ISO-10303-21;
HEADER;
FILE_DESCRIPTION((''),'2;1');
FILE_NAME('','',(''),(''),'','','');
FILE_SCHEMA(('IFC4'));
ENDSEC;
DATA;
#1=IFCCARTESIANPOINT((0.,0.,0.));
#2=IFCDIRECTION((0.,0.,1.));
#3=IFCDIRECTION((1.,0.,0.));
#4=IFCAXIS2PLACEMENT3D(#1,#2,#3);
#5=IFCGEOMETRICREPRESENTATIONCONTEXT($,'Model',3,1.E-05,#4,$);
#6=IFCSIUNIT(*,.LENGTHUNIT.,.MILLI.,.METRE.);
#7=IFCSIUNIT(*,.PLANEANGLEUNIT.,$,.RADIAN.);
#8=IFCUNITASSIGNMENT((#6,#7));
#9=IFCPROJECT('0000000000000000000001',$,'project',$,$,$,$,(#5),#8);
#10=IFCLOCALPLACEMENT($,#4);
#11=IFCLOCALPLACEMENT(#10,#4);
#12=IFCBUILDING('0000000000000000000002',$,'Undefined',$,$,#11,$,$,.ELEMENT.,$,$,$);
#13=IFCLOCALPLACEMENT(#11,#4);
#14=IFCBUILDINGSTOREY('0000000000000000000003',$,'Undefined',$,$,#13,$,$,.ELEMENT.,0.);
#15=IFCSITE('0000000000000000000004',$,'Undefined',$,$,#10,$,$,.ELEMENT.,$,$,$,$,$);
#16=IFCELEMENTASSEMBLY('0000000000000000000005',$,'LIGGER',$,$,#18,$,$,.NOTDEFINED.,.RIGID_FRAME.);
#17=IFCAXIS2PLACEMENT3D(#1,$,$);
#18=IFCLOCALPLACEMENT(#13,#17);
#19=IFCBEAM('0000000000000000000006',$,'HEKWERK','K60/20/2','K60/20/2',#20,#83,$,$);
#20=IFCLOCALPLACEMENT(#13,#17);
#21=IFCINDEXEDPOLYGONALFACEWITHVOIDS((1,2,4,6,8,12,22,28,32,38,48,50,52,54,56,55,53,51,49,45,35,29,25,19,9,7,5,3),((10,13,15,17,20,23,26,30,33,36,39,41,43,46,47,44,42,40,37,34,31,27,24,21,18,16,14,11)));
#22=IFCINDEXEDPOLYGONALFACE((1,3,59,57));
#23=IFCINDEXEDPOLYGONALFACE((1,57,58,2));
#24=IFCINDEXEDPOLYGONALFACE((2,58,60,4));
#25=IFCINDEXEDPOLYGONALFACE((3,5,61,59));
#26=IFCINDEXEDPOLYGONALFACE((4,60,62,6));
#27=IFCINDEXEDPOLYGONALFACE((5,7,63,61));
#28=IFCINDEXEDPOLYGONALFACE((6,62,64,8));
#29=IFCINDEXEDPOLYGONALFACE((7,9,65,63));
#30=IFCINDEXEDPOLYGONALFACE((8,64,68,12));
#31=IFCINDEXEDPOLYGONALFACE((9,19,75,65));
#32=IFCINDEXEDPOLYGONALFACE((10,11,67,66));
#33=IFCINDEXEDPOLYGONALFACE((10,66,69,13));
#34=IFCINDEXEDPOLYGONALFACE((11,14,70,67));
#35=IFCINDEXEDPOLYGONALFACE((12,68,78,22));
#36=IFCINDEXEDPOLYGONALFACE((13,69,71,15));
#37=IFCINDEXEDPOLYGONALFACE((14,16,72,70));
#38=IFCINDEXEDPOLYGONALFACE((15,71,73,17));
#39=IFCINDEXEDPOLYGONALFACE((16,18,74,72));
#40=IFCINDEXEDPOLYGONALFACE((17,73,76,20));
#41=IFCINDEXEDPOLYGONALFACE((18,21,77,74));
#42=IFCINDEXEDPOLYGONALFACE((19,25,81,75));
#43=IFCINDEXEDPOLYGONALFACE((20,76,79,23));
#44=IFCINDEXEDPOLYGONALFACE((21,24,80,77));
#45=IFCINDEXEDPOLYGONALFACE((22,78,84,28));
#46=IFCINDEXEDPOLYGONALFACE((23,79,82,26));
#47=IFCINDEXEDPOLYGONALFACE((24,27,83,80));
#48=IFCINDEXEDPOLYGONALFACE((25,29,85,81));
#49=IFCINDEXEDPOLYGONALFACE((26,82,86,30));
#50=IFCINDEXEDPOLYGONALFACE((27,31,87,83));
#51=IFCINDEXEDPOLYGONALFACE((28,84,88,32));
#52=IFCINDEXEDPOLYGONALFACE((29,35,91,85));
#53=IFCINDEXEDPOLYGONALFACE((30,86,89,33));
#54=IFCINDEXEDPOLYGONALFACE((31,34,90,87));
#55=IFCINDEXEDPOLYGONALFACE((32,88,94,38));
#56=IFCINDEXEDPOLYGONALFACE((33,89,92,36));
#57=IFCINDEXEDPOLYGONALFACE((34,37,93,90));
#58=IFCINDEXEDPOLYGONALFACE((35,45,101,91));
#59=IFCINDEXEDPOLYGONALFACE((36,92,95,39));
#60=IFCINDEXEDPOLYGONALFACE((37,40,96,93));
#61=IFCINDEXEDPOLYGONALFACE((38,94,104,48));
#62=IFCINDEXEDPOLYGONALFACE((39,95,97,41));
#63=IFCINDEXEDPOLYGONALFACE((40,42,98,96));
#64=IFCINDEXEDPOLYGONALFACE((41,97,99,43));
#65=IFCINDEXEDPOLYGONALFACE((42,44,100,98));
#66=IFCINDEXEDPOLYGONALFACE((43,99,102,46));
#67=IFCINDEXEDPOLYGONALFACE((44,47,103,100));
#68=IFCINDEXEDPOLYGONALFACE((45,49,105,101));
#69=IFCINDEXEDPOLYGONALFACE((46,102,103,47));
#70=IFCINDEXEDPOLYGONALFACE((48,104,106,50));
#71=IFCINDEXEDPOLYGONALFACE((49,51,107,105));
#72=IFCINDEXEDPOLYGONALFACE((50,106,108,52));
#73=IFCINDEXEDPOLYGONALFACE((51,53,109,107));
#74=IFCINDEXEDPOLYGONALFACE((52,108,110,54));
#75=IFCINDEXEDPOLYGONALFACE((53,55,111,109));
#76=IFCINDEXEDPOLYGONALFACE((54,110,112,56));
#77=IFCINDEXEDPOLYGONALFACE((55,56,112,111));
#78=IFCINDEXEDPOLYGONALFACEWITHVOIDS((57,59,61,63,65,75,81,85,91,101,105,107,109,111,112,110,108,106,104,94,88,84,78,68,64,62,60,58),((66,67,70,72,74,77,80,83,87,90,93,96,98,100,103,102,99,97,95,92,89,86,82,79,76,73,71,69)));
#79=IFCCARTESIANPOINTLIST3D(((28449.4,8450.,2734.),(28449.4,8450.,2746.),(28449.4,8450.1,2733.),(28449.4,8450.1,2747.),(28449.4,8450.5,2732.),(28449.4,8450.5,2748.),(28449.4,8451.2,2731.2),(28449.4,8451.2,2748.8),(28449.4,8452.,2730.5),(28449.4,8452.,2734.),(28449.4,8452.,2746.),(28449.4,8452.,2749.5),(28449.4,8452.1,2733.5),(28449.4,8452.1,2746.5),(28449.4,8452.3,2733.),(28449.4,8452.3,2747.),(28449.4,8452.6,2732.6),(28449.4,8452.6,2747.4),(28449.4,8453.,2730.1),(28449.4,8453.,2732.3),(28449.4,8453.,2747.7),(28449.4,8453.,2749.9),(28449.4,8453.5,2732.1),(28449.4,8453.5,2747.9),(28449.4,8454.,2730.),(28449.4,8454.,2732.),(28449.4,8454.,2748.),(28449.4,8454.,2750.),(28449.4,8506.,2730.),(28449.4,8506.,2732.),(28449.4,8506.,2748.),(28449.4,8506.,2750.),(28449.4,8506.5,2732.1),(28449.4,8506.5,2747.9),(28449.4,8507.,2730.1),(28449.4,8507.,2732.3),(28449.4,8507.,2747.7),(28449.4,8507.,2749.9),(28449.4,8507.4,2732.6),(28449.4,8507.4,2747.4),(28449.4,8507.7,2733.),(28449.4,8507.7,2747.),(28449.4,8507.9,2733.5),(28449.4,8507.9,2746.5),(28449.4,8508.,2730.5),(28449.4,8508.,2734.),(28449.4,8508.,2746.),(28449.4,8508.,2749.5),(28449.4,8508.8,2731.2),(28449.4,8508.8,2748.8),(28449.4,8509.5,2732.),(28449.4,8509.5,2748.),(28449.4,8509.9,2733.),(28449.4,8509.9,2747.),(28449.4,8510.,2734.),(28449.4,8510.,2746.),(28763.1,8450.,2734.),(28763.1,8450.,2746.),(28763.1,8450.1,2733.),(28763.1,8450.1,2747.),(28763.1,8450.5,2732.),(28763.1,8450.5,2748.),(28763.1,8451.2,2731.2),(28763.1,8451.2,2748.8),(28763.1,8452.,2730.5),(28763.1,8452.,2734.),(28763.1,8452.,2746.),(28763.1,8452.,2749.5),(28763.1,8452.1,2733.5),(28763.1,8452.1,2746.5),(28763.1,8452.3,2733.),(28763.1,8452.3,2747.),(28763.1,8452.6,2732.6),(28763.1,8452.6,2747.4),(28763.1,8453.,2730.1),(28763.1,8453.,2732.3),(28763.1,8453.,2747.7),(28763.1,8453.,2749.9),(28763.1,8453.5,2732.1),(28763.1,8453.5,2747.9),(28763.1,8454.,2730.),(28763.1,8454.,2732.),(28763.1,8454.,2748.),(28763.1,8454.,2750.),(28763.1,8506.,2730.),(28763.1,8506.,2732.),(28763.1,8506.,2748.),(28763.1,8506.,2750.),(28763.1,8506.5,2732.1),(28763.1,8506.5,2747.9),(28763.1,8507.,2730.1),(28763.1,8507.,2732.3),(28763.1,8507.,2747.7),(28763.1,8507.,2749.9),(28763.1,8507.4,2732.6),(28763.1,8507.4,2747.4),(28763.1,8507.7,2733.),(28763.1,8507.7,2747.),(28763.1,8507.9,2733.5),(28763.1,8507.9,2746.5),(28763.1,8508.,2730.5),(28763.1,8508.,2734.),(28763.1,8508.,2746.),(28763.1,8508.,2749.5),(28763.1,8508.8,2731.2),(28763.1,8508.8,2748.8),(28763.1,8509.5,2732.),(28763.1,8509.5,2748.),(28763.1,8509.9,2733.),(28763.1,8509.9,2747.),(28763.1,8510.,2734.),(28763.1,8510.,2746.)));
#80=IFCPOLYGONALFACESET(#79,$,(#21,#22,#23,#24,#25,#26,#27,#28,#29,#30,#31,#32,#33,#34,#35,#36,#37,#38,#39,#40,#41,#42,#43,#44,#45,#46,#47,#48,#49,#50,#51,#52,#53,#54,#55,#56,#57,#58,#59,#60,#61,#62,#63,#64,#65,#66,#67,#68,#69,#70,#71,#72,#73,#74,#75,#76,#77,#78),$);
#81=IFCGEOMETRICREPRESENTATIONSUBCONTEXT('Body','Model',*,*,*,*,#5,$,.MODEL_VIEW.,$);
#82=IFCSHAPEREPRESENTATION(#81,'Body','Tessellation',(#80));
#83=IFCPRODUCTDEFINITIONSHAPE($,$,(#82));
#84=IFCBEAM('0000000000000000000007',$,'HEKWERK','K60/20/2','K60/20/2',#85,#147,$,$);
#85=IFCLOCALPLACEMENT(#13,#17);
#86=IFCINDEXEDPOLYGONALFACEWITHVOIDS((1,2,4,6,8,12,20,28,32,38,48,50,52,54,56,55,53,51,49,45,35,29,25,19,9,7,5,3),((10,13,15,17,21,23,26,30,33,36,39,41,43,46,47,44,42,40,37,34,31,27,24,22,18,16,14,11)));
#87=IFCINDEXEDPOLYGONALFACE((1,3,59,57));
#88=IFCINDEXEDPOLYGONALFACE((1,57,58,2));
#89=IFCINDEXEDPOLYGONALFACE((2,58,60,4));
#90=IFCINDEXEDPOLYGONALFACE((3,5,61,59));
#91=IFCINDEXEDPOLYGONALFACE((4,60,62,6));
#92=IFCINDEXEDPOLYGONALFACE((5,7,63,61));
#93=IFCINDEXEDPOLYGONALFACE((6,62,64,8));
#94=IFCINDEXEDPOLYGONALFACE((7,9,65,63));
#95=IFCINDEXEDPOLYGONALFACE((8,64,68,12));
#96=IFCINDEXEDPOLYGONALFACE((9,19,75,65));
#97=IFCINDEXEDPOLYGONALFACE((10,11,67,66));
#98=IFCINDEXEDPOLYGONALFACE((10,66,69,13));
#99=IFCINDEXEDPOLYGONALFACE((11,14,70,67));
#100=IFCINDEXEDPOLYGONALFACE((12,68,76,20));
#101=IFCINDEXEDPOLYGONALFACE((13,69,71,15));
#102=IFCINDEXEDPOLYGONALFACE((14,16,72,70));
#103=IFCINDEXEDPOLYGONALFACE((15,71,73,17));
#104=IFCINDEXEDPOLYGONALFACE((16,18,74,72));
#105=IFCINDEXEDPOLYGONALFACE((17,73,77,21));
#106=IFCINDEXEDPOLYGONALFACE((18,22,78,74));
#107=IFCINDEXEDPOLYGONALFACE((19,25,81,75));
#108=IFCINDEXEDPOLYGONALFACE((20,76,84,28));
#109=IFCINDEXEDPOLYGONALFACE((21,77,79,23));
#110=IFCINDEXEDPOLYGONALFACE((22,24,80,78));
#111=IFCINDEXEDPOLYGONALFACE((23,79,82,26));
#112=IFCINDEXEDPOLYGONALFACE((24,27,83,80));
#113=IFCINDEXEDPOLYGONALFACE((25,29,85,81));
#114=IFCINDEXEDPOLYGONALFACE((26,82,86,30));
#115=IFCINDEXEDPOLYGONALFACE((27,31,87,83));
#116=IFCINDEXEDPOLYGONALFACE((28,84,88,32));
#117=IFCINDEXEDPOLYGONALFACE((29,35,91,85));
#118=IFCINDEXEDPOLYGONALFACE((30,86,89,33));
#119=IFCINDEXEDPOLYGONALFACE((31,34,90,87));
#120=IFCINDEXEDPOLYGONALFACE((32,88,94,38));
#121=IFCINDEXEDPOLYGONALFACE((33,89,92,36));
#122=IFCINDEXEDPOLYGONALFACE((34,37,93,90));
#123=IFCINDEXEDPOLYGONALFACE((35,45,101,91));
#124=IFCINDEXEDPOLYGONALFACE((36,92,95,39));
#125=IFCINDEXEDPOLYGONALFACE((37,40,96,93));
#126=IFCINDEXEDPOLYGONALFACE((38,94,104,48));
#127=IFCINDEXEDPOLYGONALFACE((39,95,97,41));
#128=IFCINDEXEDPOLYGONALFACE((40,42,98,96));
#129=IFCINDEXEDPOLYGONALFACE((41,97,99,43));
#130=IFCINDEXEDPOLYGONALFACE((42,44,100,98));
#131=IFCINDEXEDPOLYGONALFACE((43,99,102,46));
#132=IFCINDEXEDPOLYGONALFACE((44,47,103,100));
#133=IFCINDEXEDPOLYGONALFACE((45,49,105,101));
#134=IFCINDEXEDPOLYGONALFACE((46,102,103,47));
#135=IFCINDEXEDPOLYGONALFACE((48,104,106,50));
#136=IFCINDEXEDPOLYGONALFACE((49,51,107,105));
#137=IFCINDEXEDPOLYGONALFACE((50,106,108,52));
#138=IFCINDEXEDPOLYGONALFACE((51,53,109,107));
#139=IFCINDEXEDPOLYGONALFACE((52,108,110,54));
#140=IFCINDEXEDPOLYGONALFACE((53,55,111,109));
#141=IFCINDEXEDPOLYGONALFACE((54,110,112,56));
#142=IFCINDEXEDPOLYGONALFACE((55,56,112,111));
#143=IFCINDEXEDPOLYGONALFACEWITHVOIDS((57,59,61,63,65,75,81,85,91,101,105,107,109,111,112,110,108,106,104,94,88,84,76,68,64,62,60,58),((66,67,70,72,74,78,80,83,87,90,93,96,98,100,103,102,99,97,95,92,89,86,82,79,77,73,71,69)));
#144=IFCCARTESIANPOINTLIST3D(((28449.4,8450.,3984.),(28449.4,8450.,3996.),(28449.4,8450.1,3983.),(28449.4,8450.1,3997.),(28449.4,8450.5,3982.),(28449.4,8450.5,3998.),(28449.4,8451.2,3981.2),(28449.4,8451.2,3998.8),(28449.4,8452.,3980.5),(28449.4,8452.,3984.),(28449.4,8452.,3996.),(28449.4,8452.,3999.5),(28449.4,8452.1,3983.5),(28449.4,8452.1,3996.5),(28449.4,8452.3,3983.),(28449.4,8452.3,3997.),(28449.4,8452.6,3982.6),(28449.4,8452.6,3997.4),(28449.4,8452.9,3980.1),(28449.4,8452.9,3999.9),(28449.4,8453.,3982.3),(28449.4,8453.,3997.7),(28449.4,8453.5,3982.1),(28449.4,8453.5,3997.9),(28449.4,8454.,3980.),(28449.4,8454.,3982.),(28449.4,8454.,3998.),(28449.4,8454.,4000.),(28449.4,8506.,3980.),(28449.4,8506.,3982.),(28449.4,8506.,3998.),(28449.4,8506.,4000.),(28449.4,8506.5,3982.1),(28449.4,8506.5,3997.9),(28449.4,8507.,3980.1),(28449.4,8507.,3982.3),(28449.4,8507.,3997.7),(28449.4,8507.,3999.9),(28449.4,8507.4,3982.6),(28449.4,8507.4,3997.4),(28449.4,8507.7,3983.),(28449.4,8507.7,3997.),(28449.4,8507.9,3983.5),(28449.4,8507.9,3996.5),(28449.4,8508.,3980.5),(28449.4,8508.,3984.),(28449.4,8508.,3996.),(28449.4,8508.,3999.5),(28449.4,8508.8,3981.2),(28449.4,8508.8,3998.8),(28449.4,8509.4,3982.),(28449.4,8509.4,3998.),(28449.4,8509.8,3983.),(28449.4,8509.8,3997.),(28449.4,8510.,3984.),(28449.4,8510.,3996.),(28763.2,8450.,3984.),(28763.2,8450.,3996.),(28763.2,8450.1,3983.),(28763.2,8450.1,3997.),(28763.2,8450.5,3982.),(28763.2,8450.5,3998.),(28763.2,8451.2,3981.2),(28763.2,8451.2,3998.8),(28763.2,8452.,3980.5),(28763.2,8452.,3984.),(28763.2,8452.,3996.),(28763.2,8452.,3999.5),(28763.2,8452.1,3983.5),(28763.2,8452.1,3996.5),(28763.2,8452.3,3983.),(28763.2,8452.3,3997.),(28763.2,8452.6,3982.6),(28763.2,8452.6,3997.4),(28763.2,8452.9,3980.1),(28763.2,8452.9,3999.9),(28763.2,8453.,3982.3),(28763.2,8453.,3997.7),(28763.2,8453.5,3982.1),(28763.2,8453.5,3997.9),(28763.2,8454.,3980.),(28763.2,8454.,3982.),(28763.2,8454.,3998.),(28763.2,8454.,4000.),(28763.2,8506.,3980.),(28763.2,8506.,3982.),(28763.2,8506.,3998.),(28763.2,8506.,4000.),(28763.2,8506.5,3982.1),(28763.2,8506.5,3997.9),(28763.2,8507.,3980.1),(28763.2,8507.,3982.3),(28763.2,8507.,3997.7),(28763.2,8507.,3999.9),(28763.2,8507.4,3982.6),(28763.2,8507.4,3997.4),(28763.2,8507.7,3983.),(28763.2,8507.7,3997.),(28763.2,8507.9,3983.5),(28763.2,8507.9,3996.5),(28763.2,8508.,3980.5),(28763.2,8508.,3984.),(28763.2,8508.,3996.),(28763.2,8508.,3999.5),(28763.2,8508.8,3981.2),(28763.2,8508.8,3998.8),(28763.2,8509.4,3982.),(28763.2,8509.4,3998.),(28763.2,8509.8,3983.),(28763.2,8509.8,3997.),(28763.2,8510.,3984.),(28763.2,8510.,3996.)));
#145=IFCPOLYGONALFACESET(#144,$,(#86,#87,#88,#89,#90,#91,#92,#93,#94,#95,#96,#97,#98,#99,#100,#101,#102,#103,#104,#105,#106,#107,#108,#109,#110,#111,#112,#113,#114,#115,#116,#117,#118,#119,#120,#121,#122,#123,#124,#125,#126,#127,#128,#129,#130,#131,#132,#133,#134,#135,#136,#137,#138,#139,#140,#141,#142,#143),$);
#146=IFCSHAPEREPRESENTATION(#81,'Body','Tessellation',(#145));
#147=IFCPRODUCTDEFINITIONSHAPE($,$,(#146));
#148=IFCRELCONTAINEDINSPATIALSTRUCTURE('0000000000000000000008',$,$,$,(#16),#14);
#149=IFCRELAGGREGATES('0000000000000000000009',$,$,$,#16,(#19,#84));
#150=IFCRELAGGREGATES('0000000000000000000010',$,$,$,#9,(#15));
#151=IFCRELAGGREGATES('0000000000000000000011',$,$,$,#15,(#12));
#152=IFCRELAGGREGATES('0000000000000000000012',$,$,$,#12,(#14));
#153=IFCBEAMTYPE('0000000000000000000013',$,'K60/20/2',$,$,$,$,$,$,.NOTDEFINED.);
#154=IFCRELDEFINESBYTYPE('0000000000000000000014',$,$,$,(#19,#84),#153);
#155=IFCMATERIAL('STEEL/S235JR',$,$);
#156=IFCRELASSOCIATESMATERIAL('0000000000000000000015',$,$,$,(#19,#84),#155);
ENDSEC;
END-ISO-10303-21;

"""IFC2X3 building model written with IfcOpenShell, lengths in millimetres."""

from ifc_helpers import new_model, si_unit, frame, origin_with_axes, origin_2d_with_axis, place, context, subcontext, project, spatial, hollow_rectangle, extrude, material, type_object, element, aggregate, save


model = new_model("IFC2X3")

# Units and contexts
model_context = context("Model", 3, precision=1e-05, world=origin_with_axes())
body_context = subcontext(model_context, "Body", "Model", "MODEL_VIEW")
ifc_project = project(units=[si_unit("LENGTHUNIT", "METRE", prefix="MILLI"), si_unit("PLANEANGLEUNIT", "RADIAN")], contexts=[model_context])

# Site, building, storey
site_placement = place(None, origin_with_axes())
site = spatial("IfcSite", under=ifc_project, at=site_placement, Name="Undefined", CompositionType="ELEMENT")
building_placement = place(site_placement, origin_with_axes())
building = spatial("IfcBuilding", under=site, at=building_placement, Name="Undefined", CompositionType="ELEMENT")
storey_placement = place(building_placement, origin_with_axes())
storey = spatial("IfcBuildingStorey", under=building, at=storey_placement, Name="Undefined", CompositionType="ELEMENT", Elevation=0.0)

# Element assembly, beams
ifc_material_1 = material(Name="STEEL/S235JR")
beam_type_1 = type_object("IfcBeamType", Name="K60/20/2", PredefinedType="NOTDEFINED")
assembly_1_placement = place(storey_placement, origin_with_axes())
assembly_1 = element("IfcElementAssembly", 1, at=assembly_1_placement, inside=storey, Name="LIGGER", AssemblyPlace="NOTDEFINED", PredefinedType="RIGID_FRAME")
beam_1_placement = place(assembly_1_placement, frame((28449.4, 8480.0, 2740.0), z_axis=(0.0, 1.0, 0.0), x_axis=(1.0, 0.0, 0.0)))
beam_1 = element("IfcBeam", 2, at=beam_1_placement, type_object=beam_type_1, material=ifc_material_1, Name="HEKWERK", Description="K60/20/2", ObjectType="K60/20/2", context=body_context, shape_type="SweptSolid", body=[
    extrude(hollow_rectangle(XDim=20.0, YDim=60.0, WallThickness=2.0, InnerFilletRadius=2.0, OuterFilletRadius=4.0, at=origin_2d_with_axis()), frame((313.7, 0.0, 0.0), z_axis=(-1.0, 0.0, 0.0), x_axis=(0.0, -1.0, 0.0)), (0.0, 0.0, 1.0), 313.7),
])
beam_2_placement = place(assembly_1_placement, frame((28449.4, 8480.0, 3990.0), z_axis=(0.0, 1.0, 0.0), x_axis=(1.0, 0.0, 0.0)))
beam_2 = element("IfcBeam", 3, at=beam_2_placement, type_object=beam_type_1, material=ifc_material_1, Name="HEKWERK", Description="K60/20/2", ObjectType="K60/20/2", context=body_context, shape_type="SweptSolid", body=[
    extrude(hollow_rectangle(XDim=20.0, YDim=60.0, WallThickness=2.0, InnerFilletRadius=2.0, OuterFilletRadius=4.0, at=origin_2d_with_axis()), frame((313.7, 0.0, 0.0), z_axis=(-1.0, 0.0, 0.0), x_axis=(0.0, -1.0, 0.0)), (0.0, 0.0, 1.0), 313.7),
])

aggregate(assembly_1, [beam_1, beam_2])

save(model, "model.ifc")
